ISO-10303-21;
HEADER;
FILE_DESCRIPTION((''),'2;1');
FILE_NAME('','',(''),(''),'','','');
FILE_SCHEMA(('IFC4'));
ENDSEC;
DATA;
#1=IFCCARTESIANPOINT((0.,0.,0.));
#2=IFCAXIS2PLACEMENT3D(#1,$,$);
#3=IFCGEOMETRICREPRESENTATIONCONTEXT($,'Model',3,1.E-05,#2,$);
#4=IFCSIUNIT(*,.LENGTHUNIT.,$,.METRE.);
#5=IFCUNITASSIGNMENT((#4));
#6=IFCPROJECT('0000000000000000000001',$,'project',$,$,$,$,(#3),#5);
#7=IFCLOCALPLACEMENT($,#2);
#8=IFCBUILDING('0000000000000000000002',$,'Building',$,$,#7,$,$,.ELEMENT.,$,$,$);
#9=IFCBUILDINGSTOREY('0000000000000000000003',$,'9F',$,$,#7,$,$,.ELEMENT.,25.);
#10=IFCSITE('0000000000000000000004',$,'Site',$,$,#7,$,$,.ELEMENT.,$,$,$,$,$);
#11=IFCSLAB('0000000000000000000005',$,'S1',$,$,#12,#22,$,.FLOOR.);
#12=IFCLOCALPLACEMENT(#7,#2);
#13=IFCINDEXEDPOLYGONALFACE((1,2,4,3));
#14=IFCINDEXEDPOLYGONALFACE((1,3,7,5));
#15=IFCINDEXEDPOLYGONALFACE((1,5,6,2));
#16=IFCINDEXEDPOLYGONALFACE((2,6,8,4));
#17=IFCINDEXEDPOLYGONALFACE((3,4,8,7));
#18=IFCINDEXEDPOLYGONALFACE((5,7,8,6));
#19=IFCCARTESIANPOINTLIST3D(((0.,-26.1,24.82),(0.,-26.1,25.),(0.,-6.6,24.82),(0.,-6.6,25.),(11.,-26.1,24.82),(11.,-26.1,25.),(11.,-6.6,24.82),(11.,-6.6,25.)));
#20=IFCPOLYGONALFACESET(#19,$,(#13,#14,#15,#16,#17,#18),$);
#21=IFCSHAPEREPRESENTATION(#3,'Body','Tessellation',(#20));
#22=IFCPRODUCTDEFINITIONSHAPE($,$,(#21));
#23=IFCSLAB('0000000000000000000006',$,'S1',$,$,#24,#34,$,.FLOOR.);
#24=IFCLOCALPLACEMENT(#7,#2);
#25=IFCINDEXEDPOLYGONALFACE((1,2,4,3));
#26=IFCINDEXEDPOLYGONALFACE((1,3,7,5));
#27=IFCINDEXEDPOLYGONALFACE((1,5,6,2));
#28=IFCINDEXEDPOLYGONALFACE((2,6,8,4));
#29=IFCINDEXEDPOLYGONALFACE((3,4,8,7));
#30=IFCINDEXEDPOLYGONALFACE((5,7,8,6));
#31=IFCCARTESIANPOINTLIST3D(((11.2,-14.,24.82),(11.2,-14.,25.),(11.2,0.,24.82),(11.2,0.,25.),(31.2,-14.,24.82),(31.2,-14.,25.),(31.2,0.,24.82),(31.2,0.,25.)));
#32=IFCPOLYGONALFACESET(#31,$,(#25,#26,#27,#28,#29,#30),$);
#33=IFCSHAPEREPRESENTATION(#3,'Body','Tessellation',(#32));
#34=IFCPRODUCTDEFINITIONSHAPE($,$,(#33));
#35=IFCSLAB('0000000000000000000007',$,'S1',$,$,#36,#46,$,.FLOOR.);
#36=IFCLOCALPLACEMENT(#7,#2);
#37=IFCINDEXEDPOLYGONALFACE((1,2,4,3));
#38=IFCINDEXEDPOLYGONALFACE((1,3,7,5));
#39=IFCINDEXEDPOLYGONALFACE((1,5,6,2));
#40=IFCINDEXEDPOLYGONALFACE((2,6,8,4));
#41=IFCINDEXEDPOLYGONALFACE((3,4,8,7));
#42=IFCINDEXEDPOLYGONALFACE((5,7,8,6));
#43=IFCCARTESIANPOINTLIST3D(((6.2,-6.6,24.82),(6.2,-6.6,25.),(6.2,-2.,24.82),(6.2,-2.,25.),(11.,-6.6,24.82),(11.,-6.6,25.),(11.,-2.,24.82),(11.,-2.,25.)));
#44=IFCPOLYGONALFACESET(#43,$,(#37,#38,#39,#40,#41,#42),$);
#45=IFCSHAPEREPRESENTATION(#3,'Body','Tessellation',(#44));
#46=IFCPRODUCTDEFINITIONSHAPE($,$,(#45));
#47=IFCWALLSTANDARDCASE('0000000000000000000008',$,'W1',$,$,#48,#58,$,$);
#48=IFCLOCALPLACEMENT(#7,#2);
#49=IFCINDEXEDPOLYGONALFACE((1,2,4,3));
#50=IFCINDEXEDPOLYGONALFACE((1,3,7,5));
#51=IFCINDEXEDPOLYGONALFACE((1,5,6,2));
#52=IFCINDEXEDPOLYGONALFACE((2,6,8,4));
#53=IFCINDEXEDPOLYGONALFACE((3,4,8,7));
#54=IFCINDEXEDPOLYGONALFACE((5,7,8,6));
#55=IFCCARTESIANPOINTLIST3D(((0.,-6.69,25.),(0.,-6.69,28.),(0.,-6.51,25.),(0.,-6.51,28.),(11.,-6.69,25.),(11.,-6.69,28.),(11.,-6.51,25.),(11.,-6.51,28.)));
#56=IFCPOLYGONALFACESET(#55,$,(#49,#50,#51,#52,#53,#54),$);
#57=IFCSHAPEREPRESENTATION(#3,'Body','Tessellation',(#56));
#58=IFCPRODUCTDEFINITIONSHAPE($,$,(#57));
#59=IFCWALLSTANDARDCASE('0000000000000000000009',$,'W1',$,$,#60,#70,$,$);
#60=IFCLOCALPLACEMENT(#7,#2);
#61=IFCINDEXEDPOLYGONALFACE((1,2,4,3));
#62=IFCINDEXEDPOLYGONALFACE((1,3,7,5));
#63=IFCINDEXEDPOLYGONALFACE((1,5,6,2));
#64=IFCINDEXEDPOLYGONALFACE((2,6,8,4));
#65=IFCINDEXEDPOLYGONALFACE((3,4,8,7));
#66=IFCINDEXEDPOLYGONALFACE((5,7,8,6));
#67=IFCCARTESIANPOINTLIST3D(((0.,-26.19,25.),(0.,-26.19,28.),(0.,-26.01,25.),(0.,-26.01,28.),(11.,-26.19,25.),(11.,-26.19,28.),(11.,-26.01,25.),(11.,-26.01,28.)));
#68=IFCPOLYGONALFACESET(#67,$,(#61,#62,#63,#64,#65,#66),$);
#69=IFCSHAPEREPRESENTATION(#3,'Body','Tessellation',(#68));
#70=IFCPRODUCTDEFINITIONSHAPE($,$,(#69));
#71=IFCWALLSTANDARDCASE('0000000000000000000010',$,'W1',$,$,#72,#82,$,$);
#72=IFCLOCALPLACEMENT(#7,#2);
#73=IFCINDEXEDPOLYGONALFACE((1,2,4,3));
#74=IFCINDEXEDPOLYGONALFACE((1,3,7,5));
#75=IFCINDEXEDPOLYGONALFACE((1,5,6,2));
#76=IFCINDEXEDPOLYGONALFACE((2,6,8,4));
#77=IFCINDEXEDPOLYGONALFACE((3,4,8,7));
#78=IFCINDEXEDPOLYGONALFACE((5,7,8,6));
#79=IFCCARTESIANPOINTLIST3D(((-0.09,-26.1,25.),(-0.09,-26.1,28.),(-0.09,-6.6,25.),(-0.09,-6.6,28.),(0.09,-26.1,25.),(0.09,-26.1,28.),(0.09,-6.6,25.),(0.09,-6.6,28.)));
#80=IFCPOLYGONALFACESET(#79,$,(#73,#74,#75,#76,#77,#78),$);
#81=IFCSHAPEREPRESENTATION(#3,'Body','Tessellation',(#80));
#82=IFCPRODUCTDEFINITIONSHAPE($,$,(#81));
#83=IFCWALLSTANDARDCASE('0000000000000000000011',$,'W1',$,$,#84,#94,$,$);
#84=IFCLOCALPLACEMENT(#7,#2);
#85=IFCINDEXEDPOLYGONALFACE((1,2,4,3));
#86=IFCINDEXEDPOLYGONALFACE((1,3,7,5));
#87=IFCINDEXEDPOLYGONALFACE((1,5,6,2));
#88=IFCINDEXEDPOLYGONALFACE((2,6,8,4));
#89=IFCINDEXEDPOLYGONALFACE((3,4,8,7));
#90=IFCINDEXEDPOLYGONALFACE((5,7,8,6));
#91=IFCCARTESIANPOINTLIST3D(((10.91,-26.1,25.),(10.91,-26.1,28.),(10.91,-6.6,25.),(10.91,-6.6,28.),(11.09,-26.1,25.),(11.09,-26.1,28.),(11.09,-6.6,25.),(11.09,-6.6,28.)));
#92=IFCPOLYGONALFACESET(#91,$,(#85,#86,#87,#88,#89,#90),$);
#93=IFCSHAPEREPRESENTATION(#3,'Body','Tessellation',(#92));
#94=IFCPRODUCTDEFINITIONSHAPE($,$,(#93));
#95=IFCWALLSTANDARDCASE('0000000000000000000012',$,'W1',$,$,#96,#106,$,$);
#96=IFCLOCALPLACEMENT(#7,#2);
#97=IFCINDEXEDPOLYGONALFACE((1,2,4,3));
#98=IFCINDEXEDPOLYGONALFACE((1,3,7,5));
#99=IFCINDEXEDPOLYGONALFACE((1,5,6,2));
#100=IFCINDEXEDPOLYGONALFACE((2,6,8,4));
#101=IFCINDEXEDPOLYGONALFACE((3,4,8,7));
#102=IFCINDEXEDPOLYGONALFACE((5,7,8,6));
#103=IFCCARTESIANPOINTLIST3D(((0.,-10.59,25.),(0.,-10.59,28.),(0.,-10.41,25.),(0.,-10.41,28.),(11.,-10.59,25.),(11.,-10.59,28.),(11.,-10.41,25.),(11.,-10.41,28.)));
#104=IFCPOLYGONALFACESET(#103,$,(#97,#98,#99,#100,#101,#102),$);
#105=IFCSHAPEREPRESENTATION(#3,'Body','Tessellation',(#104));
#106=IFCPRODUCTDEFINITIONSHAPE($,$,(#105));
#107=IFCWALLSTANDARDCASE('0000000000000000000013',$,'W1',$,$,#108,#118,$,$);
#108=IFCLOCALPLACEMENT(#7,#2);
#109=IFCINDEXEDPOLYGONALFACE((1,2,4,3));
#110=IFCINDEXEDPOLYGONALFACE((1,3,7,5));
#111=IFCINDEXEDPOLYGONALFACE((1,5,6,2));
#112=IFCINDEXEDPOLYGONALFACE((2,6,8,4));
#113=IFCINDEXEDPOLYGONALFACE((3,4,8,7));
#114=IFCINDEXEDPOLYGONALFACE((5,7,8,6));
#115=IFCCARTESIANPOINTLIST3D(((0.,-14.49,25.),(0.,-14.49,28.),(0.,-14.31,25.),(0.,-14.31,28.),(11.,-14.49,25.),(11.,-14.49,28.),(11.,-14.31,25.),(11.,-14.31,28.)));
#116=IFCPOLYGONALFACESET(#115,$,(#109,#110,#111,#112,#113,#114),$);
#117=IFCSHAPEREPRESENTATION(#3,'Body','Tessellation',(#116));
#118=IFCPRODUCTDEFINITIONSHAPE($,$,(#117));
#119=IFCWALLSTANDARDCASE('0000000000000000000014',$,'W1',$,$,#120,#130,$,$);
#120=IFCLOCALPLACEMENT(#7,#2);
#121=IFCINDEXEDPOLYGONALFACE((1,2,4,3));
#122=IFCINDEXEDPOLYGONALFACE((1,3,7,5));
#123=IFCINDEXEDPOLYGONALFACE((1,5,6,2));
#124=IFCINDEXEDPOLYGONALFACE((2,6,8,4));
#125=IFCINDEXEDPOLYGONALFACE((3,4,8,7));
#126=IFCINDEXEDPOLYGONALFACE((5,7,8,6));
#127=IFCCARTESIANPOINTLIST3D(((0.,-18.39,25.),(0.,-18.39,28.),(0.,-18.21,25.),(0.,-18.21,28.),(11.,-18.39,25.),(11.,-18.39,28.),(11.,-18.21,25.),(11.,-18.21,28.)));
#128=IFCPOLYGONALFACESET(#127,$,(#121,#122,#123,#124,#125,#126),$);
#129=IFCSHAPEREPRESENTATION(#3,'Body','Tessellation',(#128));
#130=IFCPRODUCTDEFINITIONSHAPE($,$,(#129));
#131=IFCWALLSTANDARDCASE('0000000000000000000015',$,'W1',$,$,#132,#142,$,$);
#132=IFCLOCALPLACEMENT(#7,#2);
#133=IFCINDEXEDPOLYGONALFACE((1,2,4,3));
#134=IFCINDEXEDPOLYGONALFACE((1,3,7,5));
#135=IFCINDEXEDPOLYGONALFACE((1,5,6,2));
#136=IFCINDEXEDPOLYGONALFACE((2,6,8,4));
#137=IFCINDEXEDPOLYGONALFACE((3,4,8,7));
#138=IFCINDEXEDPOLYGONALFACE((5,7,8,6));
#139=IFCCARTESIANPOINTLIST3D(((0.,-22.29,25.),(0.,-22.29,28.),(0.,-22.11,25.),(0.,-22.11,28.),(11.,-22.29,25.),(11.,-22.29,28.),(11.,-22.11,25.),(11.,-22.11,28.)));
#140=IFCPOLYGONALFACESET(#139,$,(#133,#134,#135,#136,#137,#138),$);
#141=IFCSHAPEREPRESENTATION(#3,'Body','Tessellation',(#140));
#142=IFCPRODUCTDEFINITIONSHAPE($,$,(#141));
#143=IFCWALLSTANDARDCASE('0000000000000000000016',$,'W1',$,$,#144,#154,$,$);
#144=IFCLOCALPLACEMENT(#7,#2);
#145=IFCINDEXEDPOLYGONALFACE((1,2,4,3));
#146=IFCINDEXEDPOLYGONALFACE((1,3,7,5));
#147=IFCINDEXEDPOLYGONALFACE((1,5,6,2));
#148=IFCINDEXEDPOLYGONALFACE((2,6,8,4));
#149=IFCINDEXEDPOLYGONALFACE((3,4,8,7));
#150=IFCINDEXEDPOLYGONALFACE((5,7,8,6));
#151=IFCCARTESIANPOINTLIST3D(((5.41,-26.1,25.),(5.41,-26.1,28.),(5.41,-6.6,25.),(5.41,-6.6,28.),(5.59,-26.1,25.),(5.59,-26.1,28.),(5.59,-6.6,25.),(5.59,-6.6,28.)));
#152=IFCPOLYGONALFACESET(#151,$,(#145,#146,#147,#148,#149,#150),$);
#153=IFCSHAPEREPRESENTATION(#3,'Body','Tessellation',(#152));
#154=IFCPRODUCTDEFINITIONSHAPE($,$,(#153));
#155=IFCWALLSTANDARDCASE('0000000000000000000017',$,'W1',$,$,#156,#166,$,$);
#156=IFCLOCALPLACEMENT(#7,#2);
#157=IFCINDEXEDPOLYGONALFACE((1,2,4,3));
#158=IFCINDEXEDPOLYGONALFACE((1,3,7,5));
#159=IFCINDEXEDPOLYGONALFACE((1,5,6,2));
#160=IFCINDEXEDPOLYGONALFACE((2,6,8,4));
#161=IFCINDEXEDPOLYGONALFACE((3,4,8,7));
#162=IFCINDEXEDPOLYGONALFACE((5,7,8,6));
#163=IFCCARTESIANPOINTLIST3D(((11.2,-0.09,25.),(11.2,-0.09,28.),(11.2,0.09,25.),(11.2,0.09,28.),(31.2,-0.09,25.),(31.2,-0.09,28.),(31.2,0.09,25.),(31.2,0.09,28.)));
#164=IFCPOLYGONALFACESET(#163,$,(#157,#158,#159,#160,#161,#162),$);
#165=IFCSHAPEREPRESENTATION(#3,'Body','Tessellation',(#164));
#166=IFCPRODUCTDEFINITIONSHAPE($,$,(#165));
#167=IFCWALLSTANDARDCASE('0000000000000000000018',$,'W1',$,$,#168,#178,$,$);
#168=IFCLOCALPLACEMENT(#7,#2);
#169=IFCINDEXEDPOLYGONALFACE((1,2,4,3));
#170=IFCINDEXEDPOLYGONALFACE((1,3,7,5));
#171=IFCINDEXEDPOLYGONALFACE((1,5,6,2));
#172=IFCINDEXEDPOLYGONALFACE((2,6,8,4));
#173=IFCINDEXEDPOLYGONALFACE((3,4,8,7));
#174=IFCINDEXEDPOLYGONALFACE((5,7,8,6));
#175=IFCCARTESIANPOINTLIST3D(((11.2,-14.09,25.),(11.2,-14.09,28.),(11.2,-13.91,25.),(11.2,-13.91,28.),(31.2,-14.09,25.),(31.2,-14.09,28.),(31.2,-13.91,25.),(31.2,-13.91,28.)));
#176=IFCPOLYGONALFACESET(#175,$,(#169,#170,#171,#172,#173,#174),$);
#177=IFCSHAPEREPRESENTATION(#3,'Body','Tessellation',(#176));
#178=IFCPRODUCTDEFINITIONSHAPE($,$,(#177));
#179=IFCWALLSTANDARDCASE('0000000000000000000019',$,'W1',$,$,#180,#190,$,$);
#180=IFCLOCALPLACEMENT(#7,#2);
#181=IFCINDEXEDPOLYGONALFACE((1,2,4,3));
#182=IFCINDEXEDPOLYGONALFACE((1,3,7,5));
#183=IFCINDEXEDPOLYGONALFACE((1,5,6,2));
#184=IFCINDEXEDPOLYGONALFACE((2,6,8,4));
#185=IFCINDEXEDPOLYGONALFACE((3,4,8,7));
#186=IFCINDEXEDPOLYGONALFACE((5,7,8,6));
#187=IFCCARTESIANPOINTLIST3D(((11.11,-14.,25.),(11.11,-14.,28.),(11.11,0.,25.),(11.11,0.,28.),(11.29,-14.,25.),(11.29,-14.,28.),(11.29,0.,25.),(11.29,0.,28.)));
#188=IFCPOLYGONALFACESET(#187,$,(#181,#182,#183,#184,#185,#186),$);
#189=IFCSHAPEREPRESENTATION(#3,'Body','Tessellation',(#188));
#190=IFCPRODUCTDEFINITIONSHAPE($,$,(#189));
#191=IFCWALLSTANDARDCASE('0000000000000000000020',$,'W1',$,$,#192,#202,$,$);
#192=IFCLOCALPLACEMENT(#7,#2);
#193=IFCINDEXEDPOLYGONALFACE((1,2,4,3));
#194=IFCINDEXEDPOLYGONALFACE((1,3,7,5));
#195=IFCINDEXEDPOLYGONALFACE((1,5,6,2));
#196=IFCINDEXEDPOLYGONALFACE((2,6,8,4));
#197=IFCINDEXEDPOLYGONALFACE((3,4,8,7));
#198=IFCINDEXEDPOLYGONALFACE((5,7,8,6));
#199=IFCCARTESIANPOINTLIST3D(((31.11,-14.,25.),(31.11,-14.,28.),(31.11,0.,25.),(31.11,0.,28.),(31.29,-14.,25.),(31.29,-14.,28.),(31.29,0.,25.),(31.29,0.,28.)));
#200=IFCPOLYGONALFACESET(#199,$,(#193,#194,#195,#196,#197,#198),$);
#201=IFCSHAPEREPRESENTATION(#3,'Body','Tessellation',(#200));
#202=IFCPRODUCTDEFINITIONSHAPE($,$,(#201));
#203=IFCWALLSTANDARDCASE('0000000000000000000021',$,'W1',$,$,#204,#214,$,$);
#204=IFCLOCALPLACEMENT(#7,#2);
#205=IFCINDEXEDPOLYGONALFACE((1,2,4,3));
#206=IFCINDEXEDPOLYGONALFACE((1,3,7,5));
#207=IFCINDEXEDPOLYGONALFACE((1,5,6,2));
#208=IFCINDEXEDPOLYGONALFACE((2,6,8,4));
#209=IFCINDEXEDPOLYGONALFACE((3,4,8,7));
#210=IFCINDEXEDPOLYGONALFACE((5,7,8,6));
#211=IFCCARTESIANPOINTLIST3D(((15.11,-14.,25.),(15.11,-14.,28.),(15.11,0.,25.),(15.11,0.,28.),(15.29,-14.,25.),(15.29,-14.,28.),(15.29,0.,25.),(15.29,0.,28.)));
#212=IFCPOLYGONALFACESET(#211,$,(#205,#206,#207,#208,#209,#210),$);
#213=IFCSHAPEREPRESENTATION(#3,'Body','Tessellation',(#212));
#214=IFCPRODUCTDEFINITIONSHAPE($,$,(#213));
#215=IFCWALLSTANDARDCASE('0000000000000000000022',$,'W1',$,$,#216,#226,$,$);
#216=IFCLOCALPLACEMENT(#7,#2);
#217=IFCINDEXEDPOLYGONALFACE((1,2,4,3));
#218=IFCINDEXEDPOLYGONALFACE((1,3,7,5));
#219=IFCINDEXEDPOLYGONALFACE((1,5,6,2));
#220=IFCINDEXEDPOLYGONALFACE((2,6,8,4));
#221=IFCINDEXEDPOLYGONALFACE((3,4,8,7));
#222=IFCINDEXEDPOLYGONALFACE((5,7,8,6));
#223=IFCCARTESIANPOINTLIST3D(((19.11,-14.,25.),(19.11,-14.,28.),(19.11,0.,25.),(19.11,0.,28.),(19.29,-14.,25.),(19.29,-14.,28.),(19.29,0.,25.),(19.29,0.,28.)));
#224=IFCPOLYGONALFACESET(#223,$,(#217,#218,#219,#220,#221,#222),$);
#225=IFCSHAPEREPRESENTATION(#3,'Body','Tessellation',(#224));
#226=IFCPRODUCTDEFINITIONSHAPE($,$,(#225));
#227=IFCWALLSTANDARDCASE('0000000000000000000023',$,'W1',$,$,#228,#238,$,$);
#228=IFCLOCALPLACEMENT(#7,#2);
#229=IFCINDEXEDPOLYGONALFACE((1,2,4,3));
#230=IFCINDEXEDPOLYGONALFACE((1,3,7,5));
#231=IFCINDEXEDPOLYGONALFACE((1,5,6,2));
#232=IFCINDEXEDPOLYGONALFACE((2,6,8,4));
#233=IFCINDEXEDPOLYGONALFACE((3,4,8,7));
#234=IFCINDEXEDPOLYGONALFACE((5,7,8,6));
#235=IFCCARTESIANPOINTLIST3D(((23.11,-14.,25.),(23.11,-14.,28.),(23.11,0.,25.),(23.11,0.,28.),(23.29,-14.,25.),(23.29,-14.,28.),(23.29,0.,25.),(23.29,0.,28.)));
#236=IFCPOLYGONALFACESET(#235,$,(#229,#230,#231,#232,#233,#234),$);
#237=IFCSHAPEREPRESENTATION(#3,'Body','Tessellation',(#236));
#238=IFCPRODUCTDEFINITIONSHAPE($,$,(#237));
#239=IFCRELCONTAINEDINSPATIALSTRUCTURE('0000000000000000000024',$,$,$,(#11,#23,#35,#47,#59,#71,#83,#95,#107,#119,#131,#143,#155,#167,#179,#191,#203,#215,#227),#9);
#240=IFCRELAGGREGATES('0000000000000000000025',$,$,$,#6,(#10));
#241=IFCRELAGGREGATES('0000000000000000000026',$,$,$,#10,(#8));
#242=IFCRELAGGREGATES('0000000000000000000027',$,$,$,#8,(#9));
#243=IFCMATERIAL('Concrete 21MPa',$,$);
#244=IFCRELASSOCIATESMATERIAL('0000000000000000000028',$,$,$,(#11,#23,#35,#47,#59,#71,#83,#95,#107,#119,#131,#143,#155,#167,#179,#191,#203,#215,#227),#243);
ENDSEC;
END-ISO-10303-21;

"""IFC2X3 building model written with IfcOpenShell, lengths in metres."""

from ifc_helpers import new_model, si_unit, frame, origin, origin_2d, place, context, project, spatial, rectangle, extrude, material, element, save


model = new_model("IFC2X3")

# Units and contexts
model_context = context("Model", 3, precision=1e-05, world=origin())
ifc_project = project(units=[si_unit("LENGTHUNIT", "METRE")], contexts=[model_context])

# Site, building, storey
placement = place(None, origin())
site = spatial("IfcSite", under=ifc_project, at=placement, Name="Site", CompositionType="ELEMENT")
building = spatial("IfcBuilding", under=site, at=placement, Name="Building", CompositionType="ELEMENT")
storey = spatial("IfcBuildingStorey", under=building, at=placement, Name="9F", CompositionType="ELEMENT", Elevation=25.0)

# Slabs
ifc_material_1 = material(Name="Concrete 21MPa")
slab_1_placement = place(None, frame((5.5, -16.35, 24.82)))
element("IfcSlab", 1, at=slab_1_placement, inside=storey, material=ifc_material_1, Name="S1", PredefinedType="FLOOR", context=model_context, shape_type="SweptSolid", body=[
    extrude(rectangle(XDim=11.0, YDim=19.5, at=origin_2d()), origin(), (0.0, 0.0, 1.0), 0.18),
])
slab_2_placement = place(None, frame((21.2, -7.0, 24.82)))
element("IfcSlab", 2, at=slab_2_placement, inside=storey, material=ifc_material_1, Name="S1", PredefinedType="FLOOR", context=model_context, shape_type="SweptSolid", body=[
    extrude(rectangle(XDim=20.0, YDim=14.0, at=origin_2d()), origin(), (0.0, 0.0, 1.0), 0.18),
])
slab_3_placement = place(None, frame((8.6, -4.3, 24.82)))
element("IfcSlab", 3, at=slab_3_placement, inside=storey, material=ifc_material_1, Name="S1", PredefinedType="FLOOR", context=model_context, shape_type="SweptSolid", body=[
    extrude(rectangle(XDim=4.8, YDim=4.6, at=origin_2d()), origin(), (0.0, 0.0, 1.0), 0.18),
])

# Walls
for number, where, name in (
    (4, (5.5, -6.6, 25.0), "W1"),
    (5, (5.5, -26.1, 25.0), "W1"),
):
    element("IfcWallStandardCase", number, at=place(None, frame(where)), inside=storey, material=ifc_material_1, Name=name, context=model_context, shape_type="SweptSolid", body=[
        extrude(rectangle(XDim=11.0, YDim=0.18, at=origin_2d()), origin(), (0.0, 0.0, 1.0), 3.0),
    ])
for number, where, name in (
    (6, (0.0, -16.35, 25.0), "W1"),
    (7, (11.0, -16.35, 25.0), "W1"),
):
    element("IfcWallStandardCase", number, at=place(None, frame(where)), inside=storey, material=ifc_material_1, Name=name, context=model_context, shape_type="SweptSolid", body=[
        extrude(rectangle(XDim=0.18, YDim=19.5, at=origin_2d()), origin(), (0.0, 0.0, 1.0), 3.0),
    ])
for number, where, name in (
    (8, (5.5, -10.5, 25.0), "W1"),
    (9, (5.5, -14.4, 25.0), "W1"),
    (10, (5.5, -18.3, 25.0), "W1"),
    (11, (5.5, -22.2, 25.0), "W1"),
):
    element("IfcWallStandardCase", number, at=place(None, frame(where)), inside=storey, material=ifc_material_1, Name=name, context=model_context, shape_type="SweptSolid", body=[
        extrude(rectangle(XDim=11.0, YDim=0.18, at=origin_2d()), origin(), (0.0, 0.0, 1.0), 3.0),
    ])
wall_1_placement = place(None, frame((5.5, -16.35, 25.0)))
element("IfcWallStandardCase", 12, at=wall_1_placement, inside=storey, material=ifc_material_1, Name="W1", context=model_context, shape_type="SweptSolid", body=[
    extrude(rectangle(XDim=0.18, YDim=19.5, at=origin_2d()), origin(), (0.0, 0.0, 1.0), 3.0),
])
for number, where, name in (
    (13, (21.2, 0.0, 25.0), "W1"),
    (14, (21.2, -14.0, 25.0), "W1"),
):
    element("IfcWallStandardCase", number, at=place(None, frame(where)), inside=storey, material=ifc_material_1, Name=name, context=model_context, shape_type="SweptSolid", body=[
        extrude(rectangle(XDim=20.0, YDim=0.18, at=origin_2d()), origin(), (0.0, 0.0, 1.0), 3.0),
    ])
for number, where, name in (
    (15, (11.2, -7.0, 25.0), "W1"),
    (16, (31.2, -7.0, 25.0), "W1"),
    (17, (15.2, -7.0, 25.0), "W1"),
    (18, (19.2, -7.0, 25.0), "W1"),
    (19, (23.2, -7.0, 25.0), "W1"),
):
    element("IfcWallStandardCase", number, at=place(None, frame(where)), inside=storey, material=ifc_material_1, Name=name, context=model_context, shape_type="SweptSolid", body=[
        extrude(rectangle(XDim=0.18, YDim=14.0, at=origin_2d()), origin(), (0.0, 0.0, 1.0), 3.0),
    ])

save(model, "model.ifc")
